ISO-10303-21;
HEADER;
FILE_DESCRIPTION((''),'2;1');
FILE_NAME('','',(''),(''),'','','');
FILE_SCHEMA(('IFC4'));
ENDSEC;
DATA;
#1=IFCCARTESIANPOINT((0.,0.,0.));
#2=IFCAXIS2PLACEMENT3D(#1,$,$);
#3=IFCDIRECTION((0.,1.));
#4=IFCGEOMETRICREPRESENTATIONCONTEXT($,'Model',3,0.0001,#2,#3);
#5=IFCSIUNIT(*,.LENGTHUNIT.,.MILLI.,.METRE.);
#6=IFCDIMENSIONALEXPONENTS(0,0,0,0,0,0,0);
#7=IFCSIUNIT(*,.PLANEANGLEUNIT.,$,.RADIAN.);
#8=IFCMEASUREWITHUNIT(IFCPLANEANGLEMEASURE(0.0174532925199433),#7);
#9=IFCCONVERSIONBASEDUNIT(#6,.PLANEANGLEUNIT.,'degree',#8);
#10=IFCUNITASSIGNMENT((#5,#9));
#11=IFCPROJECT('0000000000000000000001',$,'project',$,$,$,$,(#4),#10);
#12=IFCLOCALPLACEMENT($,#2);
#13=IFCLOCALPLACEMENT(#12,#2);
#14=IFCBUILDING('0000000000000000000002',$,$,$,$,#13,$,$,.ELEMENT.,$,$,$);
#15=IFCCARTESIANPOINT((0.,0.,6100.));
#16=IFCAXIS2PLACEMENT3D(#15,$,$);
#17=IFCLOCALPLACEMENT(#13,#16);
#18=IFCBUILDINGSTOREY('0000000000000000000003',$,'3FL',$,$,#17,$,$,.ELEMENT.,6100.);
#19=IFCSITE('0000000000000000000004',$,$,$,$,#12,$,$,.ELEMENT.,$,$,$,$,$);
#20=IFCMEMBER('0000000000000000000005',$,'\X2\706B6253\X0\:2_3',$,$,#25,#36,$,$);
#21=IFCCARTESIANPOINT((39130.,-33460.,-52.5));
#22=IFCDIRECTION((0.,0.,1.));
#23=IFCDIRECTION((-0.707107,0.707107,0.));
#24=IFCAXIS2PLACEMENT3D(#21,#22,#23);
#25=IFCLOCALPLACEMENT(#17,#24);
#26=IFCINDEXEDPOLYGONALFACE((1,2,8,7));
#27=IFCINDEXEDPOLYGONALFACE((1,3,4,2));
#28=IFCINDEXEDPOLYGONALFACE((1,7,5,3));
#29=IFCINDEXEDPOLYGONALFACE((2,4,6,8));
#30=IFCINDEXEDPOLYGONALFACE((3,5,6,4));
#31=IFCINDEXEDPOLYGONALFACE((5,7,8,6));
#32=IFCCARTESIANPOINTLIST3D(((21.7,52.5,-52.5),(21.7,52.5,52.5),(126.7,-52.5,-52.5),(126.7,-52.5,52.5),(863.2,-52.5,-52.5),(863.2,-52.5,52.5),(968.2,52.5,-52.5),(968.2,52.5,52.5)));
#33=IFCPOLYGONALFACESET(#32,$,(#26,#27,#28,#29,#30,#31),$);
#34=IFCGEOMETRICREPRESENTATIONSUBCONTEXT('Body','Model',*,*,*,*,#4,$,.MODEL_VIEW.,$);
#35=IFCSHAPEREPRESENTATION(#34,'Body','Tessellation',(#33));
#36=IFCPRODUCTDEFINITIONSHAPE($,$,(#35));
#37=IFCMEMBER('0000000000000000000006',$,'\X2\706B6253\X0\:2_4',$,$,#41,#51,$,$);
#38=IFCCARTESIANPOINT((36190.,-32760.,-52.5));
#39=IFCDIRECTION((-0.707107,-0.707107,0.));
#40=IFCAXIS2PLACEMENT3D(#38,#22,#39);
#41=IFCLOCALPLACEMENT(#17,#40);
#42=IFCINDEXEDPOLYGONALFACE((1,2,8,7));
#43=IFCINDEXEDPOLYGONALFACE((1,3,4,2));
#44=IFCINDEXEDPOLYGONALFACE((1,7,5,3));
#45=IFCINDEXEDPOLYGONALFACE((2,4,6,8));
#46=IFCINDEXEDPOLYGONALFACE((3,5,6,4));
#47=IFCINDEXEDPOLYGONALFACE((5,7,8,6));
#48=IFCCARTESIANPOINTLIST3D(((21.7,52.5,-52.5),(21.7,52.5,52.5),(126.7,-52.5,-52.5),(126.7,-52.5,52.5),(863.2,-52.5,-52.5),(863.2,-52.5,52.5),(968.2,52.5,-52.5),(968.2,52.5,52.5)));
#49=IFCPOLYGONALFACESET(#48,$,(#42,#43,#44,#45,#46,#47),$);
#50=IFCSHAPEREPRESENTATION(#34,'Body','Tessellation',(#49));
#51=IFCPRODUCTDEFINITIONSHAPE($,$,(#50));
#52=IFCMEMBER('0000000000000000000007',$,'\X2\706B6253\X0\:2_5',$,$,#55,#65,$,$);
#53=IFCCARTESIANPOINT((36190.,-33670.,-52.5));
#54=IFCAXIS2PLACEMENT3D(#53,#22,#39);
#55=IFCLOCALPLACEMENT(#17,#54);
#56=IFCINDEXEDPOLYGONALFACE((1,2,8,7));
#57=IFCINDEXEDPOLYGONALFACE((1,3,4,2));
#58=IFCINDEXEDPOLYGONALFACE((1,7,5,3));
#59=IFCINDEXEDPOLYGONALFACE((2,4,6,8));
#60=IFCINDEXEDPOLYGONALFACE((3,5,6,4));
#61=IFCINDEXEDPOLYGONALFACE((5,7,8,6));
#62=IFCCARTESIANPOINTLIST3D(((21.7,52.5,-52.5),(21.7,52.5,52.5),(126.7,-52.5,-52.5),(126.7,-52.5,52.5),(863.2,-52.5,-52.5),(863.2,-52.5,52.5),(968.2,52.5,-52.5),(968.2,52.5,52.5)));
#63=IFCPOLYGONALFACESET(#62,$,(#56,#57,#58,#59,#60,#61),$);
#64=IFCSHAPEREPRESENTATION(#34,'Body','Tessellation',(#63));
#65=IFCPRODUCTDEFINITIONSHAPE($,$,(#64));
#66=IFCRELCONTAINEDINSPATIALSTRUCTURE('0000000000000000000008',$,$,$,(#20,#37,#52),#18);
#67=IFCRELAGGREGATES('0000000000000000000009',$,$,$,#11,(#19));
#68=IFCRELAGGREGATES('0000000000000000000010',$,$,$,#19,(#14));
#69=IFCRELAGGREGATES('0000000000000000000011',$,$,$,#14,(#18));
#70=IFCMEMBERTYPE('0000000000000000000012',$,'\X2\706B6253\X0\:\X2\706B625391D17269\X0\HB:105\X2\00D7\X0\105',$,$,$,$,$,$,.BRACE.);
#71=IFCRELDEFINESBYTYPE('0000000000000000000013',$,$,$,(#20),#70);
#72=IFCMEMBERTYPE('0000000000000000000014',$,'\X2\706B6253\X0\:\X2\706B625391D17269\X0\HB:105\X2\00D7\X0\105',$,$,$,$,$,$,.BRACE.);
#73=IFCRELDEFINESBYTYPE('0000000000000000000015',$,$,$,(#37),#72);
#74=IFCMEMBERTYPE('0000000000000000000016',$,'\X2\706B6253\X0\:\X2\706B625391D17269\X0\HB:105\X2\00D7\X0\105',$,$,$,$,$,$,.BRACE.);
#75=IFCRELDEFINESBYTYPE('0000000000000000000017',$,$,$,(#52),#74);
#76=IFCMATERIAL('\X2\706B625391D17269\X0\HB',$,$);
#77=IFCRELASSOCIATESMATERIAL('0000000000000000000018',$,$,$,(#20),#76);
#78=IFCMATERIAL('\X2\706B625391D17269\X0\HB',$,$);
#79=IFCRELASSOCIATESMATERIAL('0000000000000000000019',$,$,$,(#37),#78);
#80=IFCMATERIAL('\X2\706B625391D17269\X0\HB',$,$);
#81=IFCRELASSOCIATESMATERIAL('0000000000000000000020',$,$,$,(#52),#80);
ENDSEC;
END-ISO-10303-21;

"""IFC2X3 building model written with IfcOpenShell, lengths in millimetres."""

from ifc_helpers import new_model, entity, si_unit, converted_unit, direction, frame, origin, place, context, subcontext, project, spatial, polyline, outline, extrude, material, type_object, element, save


model = new_model("IFC2X3")

# Units and contexts
model_context = context("Model", 3, precision=0.0001, world=origin(), true_north=direction((0.0, 1.0)))
body_context = subcontext(model_context, "Body", "Model", "MODEL_VIEW")
ifc_project = project(units=[si_unit("LENGTHUNIT", "METRE", prefix="MILLI"), converted_unit("PLANEANGLEUNIT", "degree", entity("IfcPlaneAngleMeasure", 0.0174532925199433), si_unit("PLANEANGLEUNIT", "RADIAN"), dimensions=[0, 0, 0, 0, 0, 0, 0])], contexts=[model_context])

# Site, building, storey
site_placement = place(None, origin())
site = spatial("IfcSite", under=ifc_project, at=site_placement, CompositionType="ELEMENT")
building_placement = place(site_placement, origin())
building = spatial("IfcBuilding", under=site, at=building_placement, CompositionType="ELEMENT")
storey_placement = place(building_placement, frame((0.0, 0.0, 6100.0)))
storey = spatial("IfcBuildingStorey", under=building, at=storey_placement, Name="3FL", CompositionType="ELEMENT", Elevation=6100.0)

# Members
ifc_material_1 = material(Name="火打金物HB")
member_type_1 = type_object("IfcMemberType", Name="火打:火打金物HB:105×105", PredefinedType="BRACE")
member_1_placement = place(storey_placement, frame((39130.0, -33460.0, -52.5), z_axis=(0.0, 0.0, 1.0), x_axis=(-0.707107, 0.707107, 0.0)))
element("IfcMember", 1, at=member_1_placement, inside=storey, type_object=member_type_1, material=ifc_material_1, Name="火打:2_3", context=body_context, shape_type="SweptSolid", body=[
    extrude(outline(polyline([(126.7, -52.5, 0.0), (21.7, 52.5, 0.0), (968.2, 52.5, 0.0), (863.2, -52.5, 0.0), (126.7, -52.5, 0.0)])), frame((0.0, 0.0, -52.5), z_axis=(0.0, 0.0, 1.0), x_axis=(1.0, 0.0, 0.0)), (0.0, 0.0, 1.0), 105.0),
])
ifc_material_2 = material(Name="火打金物HB")
member_type_2 = type_object("IfcMemberType", Name="火打:火打金物HB:105×105", PredefinedType="BRACE")
member_2_placement = place(storey_placement, frame((36190.0, -32760.0, -52.5), z_axis=(0.0, 0.0, 1.0), x_axis=(-0.707107, -0.707107, 0.0)))
element("IfcMember", 2, at=member_2_placement, inside=storey, type_object=member_type_2, material=ifc_material_2, Name="火打:2_4", context=body_context, shape_type="SweptSolid", body=[
    extrude(outline(polyline([(126.7, -52.5, 0.0), (21.7, 52.5, 0.0), (968.2, 52.5, 0.0), (863.2, -52.5, 0.0), (126.7, -52.5, 0.0)])), frame((0.0, 0.0, -52.5), z_axis=(0.0, 0.0, 1.0), x_axis=(1.0, 0.0, 0.0)), (0.0, 0.0, 1.0), 105.0),
])
ifc_material_3 = material(Name="火打金物HB")
member_type_3 = type_object("IfcMemberType", Name="火打:火打金物HB:105×105", PredefinedType="BRACE")
member_3_placement = place(storey_placement, frame((36190.0, -33670.0, -52.5), z_axis=(0.0, 0.0, 1.0), x_axis=(-0.707107, -0.707107, 0.0)))
element("IfcMember", 3, at=member_3_placement, inside=storey, type_object=member_type_3, material=ifc_material_3, Name="火打:2_5", context=body_context, shape_type="SweptSolid", body=[
    extrude(outline(polyline([(126.7, -52.5, 0.0), (21.7, 52.5, 0.0), (968.2, 52.5, 0.0), (863.2, -52.5, 0.0), (126.7, -52.5, 0.0)])), frame((0.0, 0.0, -52.5), z_axis=(0.0, 0.0, 1.0), x_axis=(1.0, 0.0, 0.0)), (0.0, 0.0, 1.0), 105.0),
])

save(model, "model.ifc")
